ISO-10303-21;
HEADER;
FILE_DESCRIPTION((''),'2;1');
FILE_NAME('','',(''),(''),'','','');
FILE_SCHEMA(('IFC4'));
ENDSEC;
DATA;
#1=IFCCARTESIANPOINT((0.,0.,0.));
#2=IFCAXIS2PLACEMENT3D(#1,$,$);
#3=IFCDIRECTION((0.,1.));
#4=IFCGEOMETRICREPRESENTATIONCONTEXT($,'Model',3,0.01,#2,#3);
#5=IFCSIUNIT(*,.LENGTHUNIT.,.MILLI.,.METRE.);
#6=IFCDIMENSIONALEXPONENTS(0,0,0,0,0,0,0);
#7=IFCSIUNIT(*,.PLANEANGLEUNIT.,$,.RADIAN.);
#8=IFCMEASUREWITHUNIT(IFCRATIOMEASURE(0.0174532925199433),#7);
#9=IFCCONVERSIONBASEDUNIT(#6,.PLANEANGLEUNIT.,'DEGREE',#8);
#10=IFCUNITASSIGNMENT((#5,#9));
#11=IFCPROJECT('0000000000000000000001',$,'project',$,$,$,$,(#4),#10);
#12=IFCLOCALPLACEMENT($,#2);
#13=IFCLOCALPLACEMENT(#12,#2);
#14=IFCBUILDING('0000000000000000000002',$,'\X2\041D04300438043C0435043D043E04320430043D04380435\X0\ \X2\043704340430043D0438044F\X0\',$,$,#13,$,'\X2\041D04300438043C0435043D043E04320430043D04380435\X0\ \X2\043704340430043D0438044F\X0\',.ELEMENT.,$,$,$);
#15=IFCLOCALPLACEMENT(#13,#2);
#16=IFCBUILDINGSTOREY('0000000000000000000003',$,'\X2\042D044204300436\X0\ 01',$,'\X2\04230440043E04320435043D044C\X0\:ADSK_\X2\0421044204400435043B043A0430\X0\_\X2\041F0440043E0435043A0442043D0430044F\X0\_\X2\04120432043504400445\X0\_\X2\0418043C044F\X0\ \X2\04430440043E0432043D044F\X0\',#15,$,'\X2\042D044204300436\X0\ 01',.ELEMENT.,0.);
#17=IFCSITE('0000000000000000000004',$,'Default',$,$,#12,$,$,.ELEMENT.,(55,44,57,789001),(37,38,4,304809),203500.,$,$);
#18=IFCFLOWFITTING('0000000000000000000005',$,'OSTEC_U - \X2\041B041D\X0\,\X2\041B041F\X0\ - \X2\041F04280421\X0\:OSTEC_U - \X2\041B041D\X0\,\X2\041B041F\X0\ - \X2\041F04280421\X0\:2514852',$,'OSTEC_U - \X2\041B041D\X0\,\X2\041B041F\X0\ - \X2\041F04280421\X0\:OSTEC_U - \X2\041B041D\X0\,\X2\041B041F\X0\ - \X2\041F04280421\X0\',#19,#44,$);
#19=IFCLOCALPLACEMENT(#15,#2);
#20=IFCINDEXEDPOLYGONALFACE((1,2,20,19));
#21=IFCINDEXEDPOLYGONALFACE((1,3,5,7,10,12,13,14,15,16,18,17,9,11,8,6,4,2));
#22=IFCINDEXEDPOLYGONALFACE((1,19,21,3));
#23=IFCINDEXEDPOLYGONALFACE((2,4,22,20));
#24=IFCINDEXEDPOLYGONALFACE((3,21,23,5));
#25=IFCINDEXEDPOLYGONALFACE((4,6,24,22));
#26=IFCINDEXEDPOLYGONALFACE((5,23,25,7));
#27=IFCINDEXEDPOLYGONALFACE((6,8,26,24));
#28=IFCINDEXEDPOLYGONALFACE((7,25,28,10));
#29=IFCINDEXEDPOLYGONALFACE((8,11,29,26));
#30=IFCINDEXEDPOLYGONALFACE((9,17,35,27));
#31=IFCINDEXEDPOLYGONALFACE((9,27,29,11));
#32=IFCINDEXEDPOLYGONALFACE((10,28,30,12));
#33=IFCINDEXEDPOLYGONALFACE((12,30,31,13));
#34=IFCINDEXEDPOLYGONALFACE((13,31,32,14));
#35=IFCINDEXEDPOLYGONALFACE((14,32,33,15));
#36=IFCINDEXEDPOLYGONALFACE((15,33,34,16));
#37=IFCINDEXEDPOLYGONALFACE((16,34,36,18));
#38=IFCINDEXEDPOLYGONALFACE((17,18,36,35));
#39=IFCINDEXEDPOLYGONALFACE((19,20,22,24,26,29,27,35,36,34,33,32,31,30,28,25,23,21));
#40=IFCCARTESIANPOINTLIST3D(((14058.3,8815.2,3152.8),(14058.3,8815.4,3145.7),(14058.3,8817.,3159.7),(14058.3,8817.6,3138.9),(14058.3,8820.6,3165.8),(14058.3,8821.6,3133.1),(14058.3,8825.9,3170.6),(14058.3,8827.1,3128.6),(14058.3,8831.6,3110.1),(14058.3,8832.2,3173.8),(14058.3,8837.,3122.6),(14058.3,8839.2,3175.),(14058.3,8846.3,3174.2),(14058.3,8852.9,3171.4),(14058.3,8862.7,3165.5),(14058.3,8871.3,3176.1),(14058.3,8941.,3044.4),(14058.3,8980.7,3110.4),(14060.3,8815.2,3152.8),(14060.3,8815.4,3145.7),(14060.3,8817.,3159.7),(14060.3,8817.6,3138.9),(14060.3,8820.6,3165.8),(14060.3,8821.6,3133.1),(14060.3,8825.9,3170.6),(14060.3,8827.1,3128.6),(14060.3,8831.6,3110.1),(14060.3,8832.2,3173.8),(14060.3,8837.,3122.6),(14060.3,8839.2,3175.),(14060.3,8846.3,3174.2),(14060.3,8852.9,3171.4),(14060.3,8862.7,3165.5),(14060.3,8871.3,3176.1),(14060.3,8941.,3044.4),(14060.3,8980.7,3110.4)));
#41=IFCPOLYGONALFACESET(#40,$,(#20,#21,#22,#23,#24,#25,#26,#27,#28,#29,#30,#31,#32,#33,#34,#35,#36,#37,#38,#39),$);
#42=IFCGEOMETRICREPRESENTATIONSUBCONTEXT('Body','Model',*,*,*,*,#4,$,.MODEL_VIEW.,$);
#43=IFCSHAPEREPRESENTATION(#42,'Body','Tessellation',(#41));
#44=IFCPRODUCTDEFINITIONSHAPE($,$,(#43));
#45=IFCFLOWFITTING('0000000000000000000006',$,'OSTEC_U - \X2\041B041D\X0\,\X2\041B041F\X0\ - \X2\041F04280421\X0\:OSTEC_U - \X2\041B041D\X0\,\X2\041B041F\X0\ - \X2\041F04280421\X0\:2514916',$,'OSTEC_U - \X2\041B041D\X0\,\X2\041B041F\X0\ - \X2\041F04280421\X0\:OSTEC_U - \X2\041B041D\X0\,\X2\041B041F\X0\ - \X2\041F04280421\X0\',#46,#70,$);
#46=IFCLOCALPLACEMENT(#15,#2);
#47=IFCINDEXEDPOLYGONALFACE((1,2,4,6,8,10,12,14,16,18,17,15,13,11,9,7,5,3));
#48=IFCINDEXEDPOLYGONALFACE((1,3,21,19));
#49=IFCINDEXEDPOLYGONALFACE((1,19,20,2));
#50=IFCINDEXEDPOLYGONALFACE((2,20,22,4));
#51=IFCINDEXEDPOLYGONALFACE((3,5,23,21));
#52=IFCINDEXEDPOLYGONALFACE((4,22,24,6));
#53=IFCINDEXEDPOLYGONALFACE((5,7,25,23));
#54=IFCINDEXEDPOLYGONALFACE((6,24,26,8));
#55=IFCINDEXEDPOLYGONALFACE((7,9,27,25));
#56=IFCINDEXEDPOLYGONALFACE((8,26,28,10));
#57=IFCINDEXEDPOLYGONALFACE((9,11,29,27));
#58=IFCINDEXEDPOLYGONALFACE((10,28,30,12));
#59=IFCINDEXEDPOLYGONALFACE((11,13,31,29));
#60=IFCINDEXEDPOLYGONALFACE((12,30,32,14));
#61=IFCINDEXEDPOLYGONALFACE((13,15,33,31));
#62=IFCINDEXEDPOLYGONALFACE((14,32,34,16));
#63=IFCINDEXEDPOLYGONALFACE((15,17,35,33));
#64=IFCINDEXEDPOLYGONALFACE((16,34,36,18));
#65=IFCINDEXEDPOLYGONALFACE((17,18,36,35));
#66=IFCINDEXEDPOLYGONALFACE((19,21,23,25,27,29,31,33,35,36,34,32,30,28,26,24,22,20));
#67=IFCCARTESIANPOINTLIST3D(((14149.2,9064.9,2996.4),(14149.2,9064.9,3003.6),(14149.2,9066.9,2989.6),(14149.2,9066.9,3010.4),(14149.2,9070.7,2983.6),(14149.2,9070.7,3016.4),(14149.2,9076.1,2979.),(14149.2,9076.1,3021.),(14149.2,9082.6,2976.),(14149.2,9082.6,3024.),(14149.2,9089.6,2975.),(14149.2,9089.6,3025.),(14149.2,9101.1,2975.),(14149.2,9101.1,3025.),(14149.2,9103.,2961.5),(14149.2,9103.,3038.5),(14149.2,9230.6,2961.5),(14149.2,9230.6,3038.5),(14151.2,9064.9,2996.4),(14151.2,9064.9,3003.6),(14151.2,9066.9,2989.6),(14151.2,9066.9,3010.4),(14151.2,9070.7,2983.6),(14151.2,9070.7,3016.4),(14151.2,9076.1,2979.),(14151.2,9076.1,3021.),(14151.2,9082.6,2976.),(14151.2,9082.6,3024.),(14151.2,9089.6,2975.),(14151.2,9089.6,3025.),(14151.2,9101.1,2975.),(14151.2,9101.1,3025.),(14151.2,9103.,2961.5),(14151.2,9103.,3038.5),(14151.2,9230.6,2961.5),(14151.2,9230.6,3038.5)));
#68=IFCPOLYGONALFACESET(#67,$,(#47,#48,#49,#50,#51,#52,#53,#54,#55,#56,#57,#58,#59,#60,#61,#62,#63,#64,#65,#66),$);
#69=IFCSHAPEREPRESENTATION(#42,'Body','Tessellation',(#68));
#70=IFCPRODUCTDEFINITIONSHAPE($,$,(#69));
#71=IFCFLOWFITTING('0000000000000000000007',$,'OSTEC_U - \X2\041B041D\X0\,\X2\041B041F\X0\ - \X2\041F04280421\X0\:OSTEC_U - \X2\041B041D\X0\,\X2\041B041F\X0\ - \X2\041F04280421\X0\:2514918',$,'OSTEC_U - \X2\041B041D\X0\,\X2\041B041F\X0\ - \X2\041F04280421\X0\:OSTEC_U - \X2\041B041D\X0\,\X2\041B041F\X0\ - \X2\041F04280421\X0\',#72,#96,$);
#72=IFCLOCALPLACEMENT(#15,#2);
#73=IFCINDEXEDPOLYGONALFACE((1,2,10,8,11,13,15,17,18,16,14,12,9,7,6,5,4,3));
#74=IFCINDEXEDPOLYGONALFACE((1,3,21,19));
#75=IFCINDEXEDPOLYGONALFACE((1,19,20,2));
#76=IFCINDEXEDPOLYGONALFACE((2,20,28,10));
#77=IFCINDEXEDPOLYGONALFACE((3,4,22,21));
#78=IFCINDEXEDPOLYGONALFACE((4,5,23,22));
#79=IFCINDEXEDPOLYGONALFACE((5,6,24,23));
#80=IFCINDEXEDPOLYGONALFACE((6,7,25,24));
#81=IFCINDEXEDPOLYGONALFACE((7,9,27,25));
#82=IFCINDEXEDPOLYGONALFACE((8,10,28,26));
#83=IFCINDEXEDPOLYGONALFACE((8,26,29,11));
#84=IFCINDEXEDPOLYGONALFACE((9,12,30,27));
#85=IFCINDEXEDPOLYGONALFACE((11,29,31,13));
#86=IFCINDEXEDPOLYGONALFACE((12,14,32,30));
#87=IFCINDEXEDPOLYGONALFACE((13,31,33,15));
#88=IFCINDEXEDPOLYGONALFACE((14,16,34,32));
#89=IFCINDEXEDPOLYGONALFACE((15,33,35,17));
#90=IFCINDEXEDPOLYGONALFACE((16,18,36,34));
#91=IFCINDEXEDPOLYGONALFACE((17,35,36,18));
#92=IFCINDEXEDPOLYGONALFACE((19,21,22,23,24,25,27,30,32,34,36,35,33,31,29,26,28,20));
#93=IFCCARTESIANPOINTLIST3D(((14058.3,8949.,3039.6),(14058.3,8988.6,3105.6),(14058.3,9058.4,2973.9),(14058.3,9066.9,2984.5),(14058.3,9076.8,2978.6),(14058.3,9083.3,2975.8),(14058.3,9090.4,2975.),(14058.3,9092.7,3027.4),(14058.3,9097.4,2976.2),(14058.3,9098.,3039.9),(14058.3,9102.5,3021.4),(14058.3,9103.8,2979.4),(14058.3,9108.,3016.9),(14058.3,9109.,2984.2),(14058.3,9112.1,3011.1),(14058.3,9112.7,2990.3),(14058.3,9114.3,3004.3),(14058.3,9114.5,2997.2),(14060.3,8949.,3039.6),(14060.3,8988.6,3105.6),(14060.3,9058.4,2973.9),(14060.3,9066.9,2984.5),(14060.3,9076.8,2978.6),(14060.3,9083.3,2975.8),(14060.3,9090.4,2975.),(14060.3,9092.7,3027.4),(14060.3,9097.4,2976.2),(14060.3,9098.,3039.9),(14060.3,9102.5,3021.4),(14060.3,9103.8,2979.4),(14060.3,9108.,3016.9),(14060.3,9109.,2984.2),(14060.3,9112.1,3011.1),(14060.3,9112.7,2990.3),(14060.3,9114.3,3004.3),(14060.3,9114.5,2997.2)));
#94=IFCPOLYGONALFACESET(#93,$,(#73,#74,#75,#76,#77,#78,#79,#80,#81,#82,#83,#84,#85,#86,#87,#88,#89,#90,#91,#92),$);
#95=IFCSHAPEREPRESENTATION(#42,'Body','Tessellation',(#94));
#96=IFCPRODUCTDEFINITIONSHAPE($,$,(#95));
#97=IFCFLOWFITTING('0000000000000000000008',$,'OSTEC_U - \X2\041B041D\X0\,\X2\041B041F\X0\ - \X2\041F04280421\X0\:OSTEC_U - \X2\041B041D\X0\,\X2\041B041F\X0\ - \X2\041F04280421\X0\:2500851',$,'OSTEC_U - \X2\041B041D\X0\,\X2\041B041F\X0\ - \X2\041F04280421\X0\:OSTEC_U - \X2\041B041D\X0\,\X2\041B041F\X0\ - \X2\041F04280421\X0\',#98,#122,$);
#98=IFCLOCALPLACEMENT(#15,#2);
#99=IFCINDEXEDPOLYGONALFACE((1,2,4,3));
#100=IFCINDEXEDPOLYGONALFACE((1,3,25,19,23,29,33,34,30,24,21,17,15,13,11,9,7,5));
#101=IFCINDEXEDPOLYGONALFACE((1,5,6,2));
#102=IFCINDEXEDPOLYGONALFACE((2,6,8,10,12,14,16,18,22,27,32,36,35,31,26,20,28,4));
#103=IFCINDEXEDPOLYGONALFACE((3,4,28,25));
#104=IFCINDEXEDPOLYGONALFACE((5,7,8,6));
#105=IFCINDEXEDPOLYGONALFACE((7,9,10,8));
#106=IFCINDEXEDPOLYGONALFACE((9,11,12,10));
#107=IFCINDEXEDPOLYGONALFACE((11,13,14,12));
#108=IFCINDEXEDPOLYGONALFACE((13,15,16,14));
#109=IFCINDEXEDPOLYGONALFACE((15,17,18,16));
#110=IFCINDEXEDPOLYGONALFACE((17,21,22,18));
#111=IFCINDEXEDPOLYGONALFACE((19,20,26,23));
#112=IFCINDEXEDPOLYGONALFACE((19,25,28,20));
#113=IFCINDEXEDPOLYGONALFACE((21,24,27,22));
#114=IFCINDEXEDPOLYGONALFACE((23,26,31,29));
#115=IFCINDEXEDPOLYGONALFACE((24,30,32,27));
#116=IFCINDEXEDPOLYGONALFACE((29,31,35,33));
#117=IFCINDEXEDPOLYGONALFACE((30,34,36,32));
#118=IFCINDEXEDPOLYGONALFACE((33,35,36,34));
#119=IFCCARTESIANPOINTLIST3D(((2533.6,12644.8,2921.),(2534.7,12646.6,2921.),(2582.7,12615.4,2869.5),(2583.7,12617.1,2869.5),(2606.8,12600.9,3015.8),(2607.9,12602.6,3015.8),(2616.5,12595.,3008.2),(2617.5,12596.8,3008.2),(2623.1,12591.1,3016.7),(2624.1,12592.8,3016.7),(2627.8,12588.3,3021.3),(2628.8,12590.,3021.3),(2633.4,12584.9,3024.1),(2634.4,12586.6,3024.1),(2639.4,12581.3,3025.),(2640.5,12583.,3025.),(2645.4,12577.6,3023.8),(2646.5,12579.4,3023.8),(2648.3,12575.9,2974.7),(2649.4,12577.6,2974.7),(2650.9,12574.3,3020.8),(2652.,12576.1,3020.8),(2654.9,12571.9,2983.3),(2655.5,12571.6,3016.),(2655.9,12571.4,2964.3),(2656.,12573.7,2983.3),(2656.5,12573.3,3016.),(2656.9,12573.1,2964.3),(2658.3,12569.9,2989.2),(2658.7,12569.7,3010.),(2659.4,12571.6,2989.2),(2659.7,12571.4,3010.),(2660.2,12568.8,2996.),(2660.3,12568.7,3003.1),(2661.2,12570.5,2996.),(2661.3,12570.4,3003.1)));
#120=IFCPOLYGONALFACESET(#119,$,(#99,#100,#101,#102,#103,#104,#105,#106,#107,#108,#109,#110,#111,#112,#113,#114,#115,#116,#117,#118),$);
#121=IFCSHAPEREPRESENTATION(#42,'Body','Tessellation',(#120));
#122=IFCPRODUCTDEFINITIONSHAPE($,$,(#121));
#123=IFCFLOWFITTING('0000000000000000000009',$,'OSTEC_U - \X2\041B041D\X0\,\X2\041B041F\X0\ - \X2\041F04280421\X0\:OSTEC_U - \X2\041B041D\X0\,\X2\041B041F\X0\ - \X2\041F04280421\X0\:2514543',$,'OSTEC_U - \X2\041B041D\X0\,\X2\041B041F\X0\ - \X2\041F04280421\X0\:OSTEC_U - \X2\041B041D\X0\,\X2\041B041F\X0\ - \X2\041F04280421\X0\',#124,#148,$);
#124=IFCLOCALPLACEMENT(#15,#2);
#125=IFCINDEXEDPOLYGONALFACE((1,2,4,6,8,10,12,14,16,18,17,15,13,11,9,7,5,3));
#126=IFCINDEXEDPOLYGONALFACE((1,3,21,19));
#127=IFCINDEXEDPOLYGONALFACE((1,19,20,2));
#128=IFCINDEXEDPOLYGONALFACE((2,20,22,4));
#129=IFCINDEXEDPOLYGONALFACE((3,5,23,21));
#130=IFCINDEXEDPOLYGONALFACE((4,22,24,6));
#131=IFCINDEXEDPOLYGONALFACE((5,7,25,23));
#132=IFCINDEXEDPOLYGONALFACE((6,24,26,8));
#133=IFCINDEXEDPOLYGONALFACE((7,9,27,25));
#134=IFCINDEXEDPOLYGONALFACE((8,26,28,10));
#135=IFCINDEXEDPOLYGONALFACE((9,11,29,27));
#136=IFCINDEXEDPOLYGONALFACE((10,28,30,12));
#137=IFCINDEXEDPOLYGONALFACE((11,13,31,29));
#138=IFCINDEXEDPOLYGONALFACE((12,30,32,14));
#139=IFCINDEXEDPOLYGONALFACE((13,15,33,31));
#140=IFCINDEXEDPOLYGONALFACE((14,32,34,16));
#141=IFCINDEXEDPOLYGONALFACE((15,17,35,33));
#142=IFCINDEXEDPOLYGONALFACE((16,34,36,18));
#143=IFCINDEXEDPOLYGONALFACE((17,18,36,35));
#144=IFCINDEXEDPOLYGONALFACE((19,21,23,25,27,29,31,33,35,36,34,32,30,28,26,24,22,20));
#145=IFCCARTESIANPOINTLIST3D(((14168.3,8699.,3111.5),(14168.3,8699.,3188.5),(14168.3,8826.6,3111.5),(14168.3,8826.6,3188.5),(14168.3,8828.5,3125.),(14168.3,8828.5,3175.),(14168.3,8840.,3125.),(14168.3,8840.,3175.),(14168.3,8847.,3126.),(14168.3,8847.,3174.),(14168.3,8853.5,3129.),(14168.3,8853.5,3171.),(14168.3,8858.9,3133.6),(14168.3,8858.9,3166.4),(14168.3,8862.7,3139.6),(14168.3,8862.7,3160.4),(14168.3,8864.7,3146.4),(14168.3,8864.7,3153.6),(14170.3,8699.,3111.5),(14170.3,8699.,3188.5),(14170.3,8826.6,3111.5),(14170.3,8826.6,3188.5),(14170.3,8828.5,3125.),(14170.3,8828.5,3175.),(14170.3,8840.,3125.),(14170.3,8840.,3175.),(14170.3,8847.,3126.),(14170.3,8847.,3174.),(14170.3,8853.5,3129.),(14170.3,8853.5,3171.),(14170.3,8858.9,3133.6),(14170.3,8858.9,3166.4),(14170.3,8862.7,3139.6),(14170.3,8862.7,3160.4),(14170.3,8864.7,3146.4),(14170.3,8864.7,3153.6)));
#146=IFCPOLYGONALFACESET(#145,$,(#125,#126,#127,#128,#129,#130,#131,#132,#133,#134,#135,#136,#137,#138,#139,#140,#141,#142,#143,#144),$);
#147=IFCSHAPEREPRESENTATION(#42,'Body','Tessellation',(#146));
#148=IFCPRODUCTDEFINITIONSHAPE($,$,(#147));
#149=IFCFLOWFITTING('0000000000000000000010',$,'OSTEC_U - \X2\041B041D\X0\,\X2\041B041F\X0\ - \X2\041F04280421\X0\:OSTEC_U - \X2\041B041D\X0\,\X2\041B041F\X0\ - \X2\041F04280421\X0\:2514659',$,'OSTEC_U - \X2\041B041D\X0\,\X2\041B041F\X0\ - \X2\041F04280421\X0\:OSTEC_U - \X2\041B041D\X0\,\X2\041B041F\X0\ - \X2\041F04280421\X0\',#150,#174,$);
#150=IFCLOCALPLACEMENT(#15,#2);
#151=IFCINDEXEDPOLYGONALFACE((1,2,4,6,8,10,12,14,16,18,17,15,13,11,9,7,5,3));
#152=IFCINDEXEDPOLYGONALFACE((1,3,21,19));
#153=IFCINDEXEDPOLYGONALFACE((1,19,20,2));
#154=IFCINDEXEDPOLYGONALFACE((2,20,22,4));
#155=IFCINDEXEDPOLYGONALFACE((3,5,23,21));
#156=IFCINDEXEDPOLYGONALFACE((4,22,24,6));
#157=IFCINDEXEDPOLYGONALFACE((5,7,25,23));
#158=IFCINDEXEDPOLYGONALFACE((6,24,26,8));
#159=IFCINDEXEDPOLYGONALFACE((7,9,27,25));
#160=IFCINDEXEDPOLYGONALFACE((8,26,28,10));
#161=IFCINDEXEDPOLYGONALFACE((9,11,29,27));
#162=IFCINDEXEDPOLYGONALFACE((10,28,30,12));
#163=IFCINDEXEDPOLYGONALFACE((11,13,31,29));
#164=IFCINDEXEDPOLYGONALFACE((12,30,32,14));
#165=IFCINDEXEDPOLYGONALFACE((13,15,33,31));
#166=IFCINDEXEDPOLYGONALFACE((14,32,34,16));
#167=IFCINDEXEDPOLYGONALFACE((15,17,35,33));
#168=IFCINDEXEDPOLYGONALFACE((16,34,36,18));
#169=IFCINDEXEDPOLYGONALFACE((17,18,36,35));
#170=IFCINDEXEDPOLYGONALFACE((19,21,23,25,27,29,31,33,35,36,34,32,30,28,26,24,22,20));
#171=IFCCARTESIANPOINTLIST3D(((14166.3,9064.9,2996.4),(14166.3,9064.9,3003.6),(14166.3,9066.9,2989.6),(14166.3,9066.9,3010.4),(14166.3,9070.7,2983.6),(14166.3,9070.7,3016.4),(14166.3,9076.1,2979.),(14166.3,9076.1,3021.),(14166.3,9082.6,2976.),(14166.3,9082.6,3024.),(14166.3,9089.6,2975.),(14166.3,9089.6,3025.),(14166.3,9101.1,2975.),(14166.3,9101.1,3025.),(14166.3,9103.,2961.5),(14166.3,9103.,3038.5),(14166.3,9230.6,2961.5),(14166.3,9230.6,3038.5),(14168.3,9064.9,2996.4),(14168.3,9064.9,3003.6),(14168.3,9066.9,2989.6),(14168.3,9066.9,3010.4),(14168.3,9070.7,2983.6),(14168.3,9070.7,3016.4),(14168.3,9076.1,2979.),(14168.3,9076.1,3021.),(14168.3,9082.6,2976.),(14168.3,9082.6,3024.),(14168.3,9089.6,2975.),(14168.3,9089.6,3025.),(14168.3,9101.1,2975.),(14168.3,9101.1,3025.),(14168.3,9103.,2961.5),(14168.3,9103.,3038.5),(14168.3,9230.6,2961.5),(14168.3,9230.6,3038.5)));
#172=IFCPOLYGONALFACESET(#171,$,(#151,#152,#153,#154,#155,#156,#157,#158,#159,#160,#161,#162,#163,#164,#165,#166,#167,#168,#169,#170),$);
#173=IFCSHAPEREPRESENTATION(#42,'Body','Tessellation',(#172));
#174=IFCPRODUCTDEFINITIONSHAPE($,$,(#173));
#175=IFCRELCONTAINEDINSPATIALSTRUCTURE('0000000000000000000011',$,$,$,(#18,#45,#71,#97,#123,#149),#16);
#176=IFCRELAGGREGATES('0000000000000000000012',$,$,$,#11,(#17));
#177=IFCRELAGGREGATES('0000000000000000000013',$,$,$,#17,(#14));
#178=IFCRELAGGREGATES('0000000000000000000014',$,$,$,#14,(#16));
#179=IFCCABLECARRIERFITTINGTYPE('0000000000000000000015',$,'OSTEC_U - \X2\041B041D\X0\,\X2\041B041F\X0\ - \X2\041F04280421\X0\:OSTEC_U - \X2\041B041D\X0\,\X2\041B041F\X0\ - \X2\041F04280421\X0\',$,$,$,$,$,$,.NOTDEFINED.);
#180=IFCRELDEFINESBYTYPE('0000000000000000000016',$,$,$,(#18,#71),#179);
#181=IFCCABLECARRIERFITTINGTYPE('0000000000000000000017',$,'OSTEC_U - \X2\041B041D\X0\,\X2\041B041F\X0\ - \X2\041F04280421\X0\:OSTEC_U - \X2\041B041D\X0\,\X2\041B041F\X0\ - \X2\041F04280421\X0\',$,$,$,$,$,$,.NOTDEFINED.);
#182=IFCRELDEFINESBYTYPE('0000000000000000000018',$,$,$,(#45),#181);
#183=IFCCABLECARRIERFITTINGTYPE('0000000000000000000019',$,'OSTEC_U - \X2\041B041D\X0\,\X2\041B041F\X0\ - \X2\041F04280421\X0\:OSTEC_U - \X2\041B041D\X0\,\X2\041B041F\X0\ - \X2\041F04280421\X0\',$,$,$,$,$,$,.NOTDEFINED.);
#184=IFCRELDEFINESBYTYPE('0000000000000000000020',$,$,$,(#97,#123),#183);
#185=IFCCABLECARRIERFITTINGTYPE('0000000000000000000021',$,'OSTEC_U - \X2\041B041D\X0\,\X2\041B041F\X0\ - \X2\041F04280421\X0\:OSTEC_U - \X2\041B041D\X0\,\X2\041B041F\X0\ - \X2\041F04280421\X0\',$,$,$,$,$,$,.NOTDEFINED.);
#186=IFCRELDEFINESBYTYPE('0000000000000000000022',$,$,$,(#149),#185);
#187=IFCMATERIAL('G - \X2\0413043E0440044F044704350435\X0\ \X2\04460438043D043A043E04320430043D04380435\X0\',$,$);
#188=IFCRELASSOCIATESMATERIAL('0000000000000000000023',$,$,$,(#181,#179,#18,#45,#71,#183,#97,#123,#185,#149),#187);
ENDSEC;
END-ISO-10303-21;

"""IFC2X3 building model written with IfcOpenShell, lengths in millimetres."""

from ifc_helpers import new_model, entity, si_unit, converted_unit, direction, frame, frame_2d, origin, place, context, subcontext, project, spatial, polyline, circle_curve, parameter, trimmed, segment, composite_curve, outline, extrude, source, transform, mapped, material, type_object, type_shapes, element, save


model = new_model("IFC2X3")

# Units and contexts
model_context = context("Model", 3, precision=0.01, world=origin(), true_north=direction((0.0, 1.0)))
body_context = subcontext(model_context, "Body", "Model", "MODEL_VIEW")
ifc_project = project(units=[si_unit("LENGTHUNIT", "METRE", prefix="MILLI"), converted_unit("PLANEANGLEUNIT", "DEGREE", entity("IfcRatioMeasure", 0.0174532925199433), si_unit("PLANEANGLEUNIT", "RADIAN"), dimensions=[0, 0, 0, 0, 0, 0, 0])], contexts=[model_context])

# Site, building, storey
site_placement = place(None, origin())
site = spatial("IfcSite", under=ifc_project, at=site_placement, Name="Default", CompositionType="ELEMENT", RefLatitude=(55, 44, 57, 789001), RefLongitude=(37, 38, 4, 304809), RefElevation=203500.0)
building_placement = place(site_placement, origin())
building = spatial("IfcBuilding", under=site, at=building_placement, Name="Наименование здания", LongName="Наименование здания", CompositionType="ELEMENT")
storey_placement = place(building_placement, origin())
storey = spatial("IfcBuildingStorey", under=building, at=storey_placement, Name="Этаж 01", ObjectType="Уровень:ADSK_Стрелка_Проектная_Вверх_Имя уровня", LongName="Этаж 01", CompositionType="ELEMENT", Elevation=0.0)

# Flow fittings
ifc_material_1 = material(Name="G - Горячее цинкование")
cable_carrier_fitting_type_1 = type_object("IfcCableCarrierFittingType", Name="OSTEC_U - ЛН,ЛП - ПШС:OSTEC_U - ЛН,ЛП - ПШС", PredefinedType="NOTDEFINED", material=ifc_material_1)
shared_shape_1 = source(origin(), body_context, "Body", "SweptSolid", [
    extrude(outline(composite_curve([segment(trimmed(circle_curve(frame_2d((-41.5, 0.0), x_axis=(1.0, 0.0)), 25.0), [parameter(90.0)], [parameter(270.0)], True, "PARAMETER"), True, "CONTINUOUS"), segment(polyline([(-41.5, -25.0), (-30.0, -25.0)]), True, "CONTINUOUS"), segment(polyline([(-30.0, -25.0), (-28.1, -38.5)]), True, "CONTINUOUS"), segment(polyline([(-28.1, -38.5), (99.5, -38.5)]), True, "CONTINUOUS"), segment(polyline([(99.5, -38.5), (99.5, 38.5)]), True, "CONTINUOUS"), segment(polyline([(99.5, 38.5), (-28.1, 38.5)]), True, "CONTINUOUS"), segment(polyline([(-28.1, 38.5), (-30.0, 25.0)]), True, "CONTINUOUS"), segment(polyline([(-30.0, 25.0), (-41.5, 25.0)]), True, "CONTINUOUS")], self_intersect=False)), frame((41.5, 0.0, 0.0), z_axis=(0.0, 0.0, -1.0), x_axis=(1.0, 0.0, 0.0)), (0.0, 0.0, -1.0), 2.0),
])
type_shapes(cable_carrier_fitting_type_1, [shared_shape_1])
cable_carrier_fitting_type_2 = type_object("IfcCableCarrierFittingType", Name="OSTEC_U - ЛН,ЛП - ПШС:OSTEC_U - ЛН,ЛП - ПШС", PredefinedType="NOTDEFINED", material=ifc_material_1)
type_shapes(cable_carrier_fitting_type_2, [shared_shape_1])
flow_fitting_1_placement = place(storey_placement, frame((14060.3, 8840.0, 3150.0), z_axis=(-1.0, 0.0, 0.0), x_axis=(0.0, 0.857167, -0.515038)))
element("IfcFlowFitting", 1, at=flow_fitting_1_placement, inside=storey, type_object=cable_carrier_fitting_type_2, material=ifc_material_1, Name="OSTEC_U - ЛН,ЛП - ПШС:OSTEC_U - ЛН,ЛП - ПШС:2514852", ObjectType="OSTEC_U - ЛН,ЛП - ПШС:OSTEC_U - ЛН,ЛП - ПШС", context=body_context, shape_type="MappedRepresentation", body=[
    mapped(shared_shape_1, transform((0.0, 0.0, 0.0), scale=1.0)),
])
flow_fitting_2_placement = place(storey_placement, frame((14149.2, 9089.6, 3000.0), z_axis=(1.0, 0.0, 0.0), x_axis=(0.0, 1.0, 0.0)))
element("IfcFlowFitting", 2, at=flow_fitting_2_placement, inside=storey, type_object=cable_carrier_fitting_type_1, material=ifc_material_1, Name="OSTEC_U - ЛН,ЛП - ПШС:OSTEC_U - ЛН,ЛП - ПШС:2514916", ObjectType="OSTEC_U - ЛН,ЛП - ПШС:OSTEC_U - ЛН,ЛП - ПШС", context=body_context, shape_type="MappedRepresentation", body=[
    mapped(shared_shape_1, transform((0.0, 0.0, 0.0), scale=1.0)),
])
flow_fitting_3_placement = place(storey_placement, frame((14060.3, 9089.6, 3000.0), z_axis=(-1.0, 0.0, 0.0), x_axis=(0.0, -0.857167, 0.515038)))
element("IfcFlowFitting", 3, at=flow_fitting_3_placement, inside=storey, type_object=cable_carrier_fitting_type_2, material=ifc_material_1, Name="OSTEC_U - ЛН,ЛП - ПШС:OSTEC_U - ЛН,ЛП - ПШС:2514918", ObjectType="OSTEC_U - ЛН,ЛП - ПШС:OSTEC_U - ЛН,ЛП - ПШС", context=body_context, shape_type="MappedRepresentation", body=[
    mapped(shared_shape_1, transform((0.0, 0.0, 0.0), scale=1.0)),
])
cable_carrier_fitting_type_3 = type_object("IfcCableCarrierFittingType", Name="OSTEC_U - ЛН,ЛП - ПШС:OSTEC_U - ЛН,ЛП - ПШС", PredefinedType="NOTDEFINED", material=ifc_material_1)
shared_shape_2 = source(origin(), body_context, "Body", "SweptSolid", [
    extrude(outline(composite_curve([segment(trimmed(circle_curve(frame_2d((-41.5, 0.0), x_axis=(1.0, 0.0)), 25.0), [parameter(90.0)], [parameter(270.0)], True, "PARAMETER"), True, "CONTINUOUS"), segment(polyline([(-41.5, -25.0), (-30.0, -25.0)]), True, "CONTINUOUS"), segment(polyline([(-30.0, -25.0), (-28.1, -38.5)]), True, "CONTINUOUS"), segment(polyline([(-28.1, -38.5), (99.5, -38.5)]), True, "CONTINUOUS"), segment(polyline([(99.5, -38.5), (99.5, 38.5)]), True, "CONTINUOUS"), segment(polyline([(99.5, 38.5), (-28.1, 38.5)]), True, "CONTINUOUS"), segment(polyline([(-28.1, 38.5), (-30.0, 25.0)]), True, "CONTINUOUS"), segment(polyline([(-30.0, 25.0), (-41.5, 25.0)]), True, "CONTINUOUS")], self_intersect=False)), frame((41.5, 0.0, 0.0)), (0.0, 0.0, 1.0), 2.0),
])
type_shapes(cable_carrier_fitting_type_3, [shared_shape_2])
for number, where, z_axis, x_axis, name in (
    (4, (2639.0, 12581.5, 3000.0), (0.515038, 0.857167, 0.0), (-0.573557, 0.344628, -0.743145), "OSTEC_U - ЛН,ЛП - ПШС:OSTEC_U - ЛН,ЛП - ПШС:2500851"),
    (5, (14170.3, 8840.0, 3150.0), (-1.0, 0.0, 0.0), (0.0, -1.0, 0.0), "OSTEC_U - ЛН,ЛП - ПШС:OSTEC_U - ЛН,ЛП - ПШС:2514543"),
):
    element("IfcFlowFitting", number, at=place(storey_placement, frame(where, z_axis=z_axis, x_axis=x_axis)), inside=storey, type_object=cable_carrier_fitting_type_3, material=ifc_material_1, Name=name, ObjectType="OSTEC_U - ЛН,ЛП - ПШС:OSTEC_U - ЛН,ЛП - ПШС", context=body_context, shape_type="MappedRepresentation", body=[
        mapped(shared_shape_2, transform((0.0, 0.0, 0.0), scale=1.0)),
    ])
cable_carrier_fitting_type_4 = type_object("IfcCableCarrierFittingType", Name="OSTEC_U - ЛН,ЛП - ПШС:OSTEC_U - ЛН,ЛП - ПШС", PredefinedType="NOTDEFINED", material=ifc_material_1)
type_shapes(cable_carrier_fitting_type_4, [shared_shape_2])
for number, where, z_axis, x_axis, name in (
    (6, (14168.3, 9089.6, 3000.0), (-1.0, 0.0, 0.0), (0.0, 1.0, 0.0), "OSTEC_U - ЛН,ЛП - ПШС:OSTEC_U - ЛН,ЛП - ПШС:2514659"),
):
    element("IfcFlowFitting", number, at=place(storey_placement, frame(where, z_axis=z_axis, x_axis=x_axis)), inside=storey, type_object=cable_carrier_fitting_type_4, material=ifc_material_1, Name=name, ObjectType="OSTEC_U - ЛН,ЛП - ПШС:OSTEC_U - ЛН,ЛП - ПШС", context=body_context, shape_type="MappedRepresentation", body=[
        mapped(shared_shape_2, transform((0.0, 0.0, 0.0), scale=1.0)),
    ])

save(model, "model.ifc")
